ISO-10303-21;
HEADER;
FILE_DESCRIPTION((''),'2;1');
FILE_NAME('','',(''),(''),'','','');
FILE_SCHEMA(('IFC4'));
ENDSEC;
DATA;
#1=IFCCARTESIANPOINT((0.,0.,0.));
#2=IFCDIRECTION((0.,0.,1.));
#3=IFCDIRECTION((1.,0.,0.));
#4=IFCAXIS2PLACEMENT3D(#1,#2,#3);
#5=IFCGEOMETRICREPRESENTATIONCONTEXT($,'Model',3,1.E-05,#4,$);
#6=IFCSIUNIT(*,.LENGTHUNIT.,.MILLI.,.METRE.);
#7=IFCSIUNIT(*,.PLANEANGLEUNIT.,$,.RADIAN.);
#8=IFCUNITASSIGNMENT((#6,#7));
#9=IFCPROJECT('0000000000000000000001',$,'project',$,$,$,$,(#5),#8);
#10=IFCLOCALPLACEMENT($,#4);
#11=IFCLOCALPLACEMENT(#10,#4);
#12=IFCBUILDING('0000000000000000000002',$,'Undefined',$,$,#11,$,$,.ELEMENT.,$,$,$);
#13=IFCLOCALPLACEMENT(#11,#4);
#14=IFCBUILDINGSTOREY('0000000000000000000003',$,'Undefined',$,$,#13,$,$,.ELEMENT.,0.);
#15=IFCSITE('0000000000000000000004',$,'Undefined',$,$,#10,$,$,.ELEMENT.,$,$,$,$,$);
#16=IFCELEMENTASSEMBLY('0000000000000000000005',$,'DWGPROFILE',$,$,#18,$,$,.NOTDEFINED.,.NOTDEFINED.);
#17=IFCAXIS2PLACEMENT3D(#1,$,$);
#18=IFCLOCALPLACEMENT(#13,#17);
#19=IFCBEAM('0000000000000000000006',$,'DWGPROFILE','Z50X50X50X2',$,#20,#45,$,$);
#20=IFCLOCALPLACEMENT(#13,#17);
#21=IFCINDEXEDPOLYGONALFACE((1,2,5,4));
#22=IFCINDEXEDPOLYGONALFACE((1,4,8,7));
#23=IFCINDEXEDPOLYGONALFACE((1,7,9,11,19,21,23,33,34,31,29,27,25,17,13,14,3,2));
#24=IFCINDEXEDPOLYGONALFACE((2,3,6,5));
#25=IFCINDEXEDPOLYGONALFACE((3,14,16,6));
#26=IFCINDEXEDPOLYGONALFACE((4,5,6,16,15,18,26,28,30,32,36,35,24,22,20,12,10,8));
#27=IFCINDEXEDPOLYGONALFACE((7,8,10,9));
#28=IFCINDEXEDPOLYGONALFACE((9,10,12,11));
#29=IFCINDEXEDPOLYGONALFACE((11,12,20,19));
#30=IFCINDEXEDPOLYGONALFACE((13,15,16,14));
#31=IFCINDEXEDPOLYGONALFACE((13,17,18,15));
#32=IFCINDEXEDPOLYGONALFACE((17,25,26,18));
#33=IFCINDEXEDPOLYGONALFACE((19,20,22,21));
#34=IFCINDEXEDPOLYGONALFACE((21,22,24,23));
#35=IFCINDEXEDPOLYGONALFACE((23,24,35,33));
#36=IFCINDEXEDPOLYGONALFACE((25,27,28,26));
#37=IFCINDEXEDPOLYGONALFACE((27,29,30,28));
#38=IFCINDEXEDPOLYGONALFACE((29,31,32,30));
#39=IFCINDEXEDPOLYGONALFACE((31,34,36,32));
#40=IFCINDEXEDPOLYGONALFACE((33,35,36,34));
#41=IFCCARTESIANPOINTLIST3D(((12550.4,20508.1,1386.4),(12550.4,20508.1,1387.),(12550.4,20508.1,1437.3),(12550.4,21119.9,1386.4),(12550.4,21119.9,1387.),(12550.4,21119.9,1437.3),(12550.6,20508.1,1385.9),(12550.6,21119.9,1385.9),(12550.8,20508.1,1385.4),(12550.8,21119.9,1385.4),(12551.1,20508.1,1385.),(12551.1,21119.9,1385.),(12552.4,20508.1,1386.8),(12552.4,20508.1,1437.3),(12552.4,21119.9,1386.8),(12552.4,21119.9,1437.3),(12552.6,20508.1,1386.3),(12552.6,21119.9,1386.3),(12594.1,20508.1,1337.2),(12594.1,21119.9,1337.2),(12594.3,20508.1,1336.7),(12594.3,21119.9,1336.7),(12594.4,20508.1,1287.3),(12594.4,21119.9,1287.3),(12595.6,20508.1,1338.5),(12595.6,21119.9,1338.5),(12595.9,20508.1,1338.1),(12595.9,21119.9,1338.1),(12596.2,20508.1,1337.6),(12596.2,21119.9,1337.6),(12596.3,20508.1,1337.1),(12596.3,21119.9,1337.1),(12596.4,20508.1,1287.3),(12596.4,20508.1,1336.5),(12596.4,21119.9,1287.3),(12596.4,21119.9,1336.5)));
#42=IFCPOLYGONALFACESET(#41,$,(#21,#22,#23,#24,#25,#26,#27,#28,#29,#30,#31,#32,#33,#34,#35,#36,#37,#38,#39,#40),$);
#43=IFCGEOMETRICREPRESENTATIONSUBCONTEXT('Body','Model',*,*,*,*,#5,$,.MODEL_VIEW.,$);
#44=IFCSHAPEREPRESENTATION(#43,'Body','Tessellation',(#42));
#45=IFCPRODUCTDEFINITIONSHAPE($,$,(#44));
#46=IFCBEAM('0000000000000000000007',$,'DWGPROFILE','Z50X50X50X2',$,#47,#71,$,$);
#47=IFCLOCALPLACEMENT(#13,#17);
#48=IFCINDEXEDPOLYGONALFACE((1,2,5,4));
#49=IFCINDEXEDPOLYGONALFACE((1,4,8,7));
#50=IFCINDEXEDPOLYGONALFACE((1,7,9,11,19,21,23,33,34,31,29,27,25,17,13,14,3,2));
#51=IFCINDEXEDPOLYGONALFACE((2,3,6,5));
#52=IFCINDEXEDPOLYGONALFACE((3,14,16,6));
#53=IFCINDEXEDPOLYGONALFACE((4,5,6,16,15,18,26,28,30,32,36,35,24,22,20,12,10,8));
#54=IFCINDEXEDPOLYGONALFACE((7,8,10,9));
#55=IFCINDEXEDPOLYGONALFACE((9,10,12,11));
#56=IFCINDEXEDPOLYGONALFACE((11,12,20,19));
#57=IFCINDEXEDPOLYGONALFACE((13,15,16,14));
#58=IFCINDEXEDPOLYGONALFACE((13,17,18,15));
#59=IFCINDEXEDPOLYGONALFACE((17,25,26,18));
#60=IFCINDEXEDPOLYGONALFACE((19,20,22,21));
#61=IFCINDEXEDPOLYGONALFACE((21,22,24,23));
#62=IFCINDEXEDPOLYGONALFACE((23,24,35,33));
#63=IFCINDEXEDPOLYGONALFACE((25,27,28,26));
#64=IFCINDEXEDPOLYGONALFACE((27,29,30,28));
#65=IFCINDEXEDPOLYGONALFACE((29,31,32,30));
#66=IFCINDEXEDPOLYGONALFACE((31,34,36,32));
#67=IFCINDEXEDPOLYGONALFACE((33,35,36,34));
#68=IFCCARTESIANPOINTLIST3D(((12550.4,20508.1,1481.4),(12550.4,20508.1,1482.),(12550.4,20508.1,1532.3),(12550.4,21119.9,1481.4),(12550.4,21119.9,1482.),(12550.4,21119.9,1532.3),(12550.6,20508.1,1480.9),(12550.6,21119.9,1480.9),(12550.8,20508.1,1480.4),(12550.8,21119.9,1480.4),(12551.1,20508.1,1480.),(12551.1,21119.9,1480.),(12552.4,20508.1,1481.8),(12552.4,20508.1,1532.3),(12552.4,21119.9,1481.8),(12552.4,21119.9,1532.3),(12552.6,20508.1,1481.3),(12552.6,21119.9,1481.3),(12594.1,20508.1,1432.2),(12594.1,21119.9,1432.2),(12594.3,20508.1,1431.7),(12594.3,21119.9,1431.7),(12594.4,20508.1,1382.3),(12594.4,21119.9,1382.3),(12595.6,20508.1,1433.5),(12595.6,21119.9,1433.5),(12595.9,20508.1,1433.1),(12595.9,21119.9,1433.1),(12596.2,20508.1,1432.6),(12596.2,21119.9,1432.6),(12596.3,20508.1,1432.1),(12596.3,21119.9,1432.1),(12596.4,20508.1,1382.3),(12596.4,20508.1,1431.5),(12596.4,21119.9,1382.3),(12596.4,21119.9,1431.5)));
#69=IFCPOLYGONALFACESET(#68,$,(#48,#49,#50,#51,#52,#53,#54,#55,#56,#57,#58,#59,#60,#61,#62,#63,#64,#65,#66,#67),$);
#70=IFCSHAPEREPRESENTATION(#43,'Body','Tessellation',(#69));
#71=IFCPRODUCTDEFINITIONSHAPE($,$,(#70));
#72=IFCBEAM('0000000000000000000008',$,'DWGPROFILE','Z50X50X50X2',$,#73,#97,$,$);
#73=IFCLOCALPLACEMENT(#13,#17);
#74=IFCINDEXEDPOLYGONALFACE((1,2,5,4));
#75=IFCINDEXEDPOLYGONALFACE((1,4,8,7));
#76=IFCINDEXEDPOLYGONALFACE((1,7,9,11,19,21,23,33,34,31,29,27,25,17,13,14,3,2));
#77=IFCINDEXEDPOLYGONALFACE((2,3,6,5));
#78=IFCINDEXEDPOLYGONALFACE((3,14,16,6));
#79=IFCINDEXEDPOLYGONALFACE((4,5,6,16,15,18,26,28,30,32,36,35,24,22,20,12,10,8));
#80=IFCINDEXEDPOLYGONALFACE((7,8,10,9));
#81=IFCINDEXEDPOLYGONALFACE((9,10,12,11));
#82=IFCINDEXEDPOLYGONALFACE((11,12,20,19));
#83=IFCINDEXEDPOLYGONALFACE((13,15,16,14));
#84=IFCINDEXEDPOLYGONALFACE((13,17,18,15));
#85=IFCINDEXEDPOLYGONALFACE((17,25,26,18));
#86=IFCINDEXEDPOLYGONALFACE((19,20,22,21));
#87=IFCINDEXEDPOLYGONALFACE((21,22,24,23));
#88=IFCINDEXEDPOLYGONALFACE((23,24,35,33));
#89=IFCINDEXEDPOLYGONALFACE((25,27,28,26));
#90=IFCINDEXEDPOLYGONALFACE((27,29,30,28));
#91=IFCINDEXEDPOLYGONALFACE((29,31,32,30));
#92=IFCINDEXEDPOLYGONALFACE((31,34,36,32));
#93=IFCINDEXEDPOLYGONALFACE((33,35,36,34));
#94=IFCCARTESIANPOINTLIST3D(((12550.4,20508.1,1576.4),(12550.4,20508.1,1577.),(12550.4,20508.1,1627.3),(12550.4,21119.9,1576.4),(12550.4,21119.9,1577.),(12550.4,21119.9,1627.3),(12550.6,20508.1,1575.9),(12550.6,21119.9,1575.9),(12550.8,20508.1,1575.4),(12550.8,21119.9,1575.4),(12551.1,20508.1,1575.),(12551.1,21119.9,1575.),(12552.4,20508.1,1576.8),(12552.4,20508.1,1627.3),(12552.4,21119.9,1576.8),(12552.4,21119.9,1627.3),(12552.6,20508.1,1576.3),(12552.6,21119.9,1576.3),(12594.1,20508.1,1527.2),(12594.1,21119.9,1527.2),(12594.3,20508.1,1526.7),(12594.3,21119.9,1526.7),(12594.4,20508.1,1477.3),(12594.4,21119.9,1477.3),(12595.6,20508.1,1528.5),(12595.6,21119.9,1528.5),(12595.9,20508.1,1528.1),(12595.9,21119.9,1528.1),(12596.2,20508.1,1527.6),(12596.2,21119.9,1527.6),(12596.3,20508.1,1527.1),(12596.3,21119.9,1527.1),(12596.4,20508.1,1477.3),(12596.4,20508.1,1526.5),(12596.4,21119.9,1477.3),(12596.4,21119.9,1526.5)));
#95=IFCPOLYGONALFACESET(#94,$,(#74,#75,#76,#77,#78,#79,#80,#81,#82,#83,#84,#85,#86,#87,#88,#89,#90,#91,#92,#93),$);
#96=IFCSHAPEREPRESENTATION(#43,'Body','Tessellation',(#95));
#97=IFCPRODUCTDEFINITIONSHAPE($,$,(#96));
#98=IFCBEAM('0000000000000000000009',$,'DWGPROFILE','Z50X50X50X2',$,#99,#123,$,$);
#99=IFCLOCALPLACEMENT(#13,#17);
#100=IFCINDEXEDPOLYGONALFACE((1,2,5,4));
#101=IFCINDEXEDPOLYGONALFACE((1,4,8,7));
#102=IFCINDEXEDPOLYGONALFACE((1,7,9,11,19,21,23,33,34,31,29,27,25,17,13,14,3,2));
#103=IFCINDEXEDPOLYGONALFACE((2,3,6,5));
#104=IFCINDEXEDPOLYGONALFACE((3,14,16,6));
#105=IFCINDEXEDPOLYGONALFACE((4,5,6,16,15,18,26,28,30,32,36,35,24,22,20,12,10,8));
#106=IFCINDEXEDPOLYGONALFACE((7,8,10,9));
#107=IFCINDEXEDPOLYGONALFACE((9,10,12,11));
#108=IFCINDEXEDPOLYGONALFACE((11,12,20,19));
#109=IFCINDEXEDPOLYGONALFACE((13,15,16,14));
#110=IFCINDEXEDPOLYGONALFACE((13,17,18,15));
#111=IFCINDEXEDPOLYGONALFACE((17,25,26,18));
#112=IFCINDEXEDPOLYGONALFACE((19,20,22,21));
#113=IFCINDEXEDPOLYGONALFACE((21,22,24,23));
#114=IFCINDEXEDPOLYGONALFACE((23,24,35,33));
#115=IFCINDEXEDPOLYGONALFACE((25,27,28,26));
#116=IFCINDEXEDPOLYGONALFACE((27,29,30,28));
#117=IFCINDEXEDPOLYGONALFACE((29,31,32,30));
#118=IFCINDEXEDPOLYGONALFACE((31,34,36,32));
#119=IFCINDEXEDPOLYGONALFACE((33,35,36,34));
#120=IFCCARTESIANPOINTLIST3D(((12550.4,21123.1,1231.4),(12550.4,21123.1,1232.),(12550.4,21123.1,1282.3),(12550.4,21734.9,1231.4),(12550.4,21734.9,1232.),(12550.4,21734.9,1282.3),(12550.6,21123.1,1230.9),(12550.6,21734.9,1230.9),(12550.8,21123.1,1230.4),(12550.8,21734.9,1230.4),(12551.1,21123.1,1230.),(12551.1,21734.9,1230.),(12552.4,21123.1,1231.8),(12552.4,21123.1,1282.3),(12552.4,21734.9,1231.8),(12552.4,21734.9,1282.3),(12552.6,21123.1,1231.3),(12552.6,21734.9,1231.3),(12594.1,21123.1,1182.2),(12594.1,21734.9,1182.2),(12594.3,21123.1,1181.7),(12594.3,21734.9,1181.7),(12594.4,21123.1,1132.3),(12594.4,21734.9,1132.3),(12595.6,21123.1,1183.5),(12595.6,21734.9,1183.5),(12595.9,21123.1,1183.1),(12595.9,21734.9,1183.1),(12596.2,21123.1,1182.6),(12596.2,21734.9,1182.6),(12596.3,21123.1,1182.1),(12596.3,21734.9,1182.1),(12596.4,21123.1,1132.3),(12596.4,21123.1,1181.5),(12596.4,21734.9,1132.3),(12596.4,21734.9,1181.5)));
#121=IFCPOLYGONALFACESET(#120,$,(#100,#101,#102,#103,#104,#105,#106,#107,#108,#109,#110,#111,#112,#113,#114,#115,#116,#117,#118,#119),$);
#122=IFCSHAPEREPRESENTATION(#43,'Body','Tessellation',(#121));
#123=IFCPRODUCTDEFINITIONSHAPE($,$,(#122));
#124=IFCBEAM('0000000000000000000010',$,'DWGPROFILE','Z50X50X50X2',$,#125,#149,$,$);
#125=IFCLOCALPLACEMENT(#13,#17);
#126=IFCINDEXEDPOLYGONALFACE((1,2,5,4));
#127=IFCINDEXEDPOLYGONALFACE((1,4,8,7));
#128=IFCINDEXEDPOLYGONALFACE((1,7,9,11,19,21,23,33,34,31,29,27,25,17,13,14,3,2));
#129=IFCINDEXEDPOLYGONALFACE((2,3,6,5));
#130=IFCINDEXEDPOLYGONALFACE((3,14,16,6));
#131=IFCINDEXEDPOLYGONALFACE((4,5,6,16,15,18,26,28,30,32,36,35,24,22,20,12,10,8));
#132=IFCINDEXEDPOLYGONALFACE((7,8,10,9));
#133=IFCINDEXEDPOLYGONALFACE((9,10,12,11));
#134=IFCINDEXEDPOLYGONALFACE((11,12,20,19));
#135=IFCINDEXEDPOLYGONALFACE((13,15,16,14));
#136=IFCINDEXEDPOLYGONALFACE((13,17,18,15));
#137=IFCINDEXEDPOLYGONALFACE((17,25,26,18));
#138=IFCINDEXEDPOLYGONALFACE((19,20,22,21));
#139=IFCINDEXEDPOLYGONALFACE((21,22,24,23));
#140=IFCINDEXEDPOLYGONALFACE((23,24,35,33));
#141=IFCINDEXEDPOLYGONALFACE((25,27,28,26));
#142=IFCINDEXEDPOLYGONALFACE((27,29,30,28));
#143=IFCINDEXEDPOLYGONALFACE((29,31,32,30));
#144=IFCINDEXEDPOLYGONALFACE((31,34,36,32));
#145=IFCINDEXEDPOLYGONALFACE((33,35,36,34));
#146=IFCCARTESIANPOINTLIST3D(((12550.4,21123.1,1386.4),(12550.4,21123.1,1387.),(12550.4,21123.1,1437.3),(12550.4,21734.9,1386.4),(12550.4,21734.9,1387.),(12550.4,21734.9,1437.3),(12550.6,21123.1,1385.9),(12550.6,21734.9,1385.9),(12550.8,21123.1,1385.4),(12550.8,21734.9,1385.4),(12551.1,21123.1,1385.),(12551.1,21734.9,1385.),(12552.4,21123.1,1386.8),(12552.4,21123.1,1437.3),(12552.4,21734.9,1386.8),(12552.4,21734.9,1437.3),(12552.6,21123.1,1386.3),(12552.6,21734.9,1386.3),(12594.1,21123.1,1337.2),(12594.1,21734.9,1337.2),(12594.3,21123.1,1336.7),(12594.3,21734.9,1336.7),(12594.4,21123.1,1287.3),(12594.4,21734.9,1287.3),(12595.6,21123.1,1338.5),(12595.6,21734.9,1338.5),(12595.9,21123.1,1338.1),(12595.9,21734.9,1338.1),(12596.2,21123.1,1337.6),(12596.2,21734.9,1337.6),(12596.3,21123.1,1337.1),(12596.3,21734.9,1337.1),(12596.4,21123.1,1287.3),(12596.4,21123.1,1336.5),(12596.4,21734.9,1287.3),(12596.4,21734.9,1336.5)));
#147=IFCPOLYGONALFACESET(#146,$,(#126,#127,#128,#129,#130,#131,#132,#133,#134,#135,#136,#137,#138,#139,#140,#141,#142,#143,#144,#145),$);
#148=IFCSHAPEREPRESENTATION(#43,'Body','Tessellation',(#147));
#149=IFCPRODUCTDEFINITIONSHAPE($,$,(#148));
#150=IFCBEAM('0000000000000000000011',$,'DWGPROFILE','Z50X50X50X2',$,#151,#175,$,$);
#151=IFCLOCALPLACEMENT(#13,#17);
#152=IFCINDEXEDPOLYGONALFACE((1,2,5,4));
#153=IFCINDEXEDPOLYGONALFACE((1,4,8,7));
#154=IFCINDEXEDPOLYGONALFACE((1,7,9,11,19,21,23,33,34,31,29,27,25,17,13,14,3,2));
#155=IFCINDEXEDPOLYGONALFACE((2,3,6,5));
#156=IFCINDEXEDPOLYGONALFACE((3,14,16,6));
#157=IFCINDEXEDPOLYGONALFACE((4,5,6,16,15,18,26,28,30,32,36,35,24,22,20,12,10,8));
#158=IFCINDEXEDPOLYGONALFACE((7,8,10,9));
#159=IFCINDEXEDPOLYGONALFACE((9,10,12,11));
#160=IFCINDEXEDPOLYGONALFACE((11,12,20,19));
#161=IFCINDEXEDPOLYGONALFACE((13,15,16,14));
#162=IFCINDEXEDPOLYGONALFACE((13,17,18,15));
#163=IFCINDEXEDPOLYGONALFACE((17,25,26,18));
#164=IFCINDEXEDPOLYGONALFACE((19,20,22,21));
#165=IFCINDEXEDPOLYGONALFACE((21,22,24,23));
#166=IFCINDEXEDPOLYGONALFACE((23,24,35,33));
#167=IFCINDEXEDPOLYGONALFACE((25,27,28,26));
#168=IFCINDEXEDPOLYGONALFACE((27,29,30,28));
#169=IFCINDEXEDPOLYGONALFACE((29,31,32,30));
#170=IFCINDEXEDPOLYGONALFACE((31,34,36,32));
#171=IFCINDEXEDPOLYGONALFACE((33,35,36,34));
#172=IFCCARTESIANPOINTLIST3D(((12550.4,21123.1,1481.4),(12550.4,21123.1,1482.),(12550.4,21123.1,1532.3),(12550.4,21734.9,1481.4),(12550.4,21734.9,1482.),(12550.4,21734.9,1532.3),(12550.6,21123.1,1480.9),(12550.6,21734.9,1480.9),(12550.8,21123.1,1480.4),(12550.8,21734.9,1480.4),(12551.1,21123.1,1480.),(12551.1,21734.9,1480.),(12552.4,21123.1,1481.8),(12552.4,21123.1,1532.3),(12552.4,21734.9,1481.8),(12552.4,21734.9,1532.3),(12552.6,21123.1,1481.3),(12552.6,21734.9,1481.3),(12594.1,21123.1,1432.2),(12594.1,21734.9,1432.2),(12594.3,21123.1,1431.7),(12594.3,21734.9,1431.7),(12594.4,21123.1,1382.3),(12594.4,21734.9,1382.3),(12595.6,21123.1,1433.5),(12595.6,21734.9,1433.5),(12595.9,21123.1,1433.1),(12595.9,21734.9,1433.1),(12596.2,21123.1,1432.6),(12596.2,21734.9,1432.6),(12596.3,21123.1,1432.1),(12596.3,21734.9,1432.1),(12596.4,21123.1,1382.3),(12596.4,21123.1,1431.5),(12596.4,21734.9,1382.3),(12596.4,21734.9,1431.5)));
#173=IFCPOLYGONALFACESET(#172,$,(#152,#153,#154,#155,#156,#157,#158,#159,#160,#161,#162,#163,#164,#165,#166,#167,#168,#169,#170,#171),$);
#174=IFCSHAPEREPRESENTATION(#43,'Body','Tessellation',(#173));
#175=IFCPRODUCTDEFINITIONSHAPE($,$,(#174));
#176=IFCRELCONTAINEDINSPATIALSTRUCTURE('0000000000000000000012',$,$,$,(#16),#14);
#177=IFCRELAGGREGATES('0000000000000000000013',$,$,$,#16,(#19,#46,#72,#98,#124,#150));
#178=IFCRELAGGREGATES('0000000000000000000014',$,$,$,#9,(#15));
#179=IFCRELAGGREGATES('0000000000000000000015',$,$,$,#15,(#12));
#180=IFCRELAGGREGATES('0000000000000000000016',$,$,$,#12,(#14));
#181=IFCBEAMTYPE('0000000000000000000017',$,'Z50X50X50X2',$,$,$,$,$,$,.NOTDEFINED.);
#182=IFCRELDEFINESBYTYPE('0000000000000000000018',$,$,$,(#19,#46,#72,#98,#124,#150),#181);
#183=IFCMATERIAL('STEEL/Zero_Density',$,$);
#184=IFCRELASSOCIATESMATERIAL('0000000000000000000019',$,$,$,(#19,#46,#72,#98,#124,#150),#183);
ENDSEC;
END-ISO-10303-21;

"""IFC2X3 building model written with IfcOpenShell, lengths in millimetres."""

from ifc_helpers import new_model, si_unit, frame, origin_with_axes, place, context, subcontext, project, spatial, polyline, outline, extrude, material, type_object, element, aggregate, save


model = new_model("IFC2X3")

# Units and contexts
model_context = context("Model", 3, precision=1e-05, world=origin_with_axes())
body_context = subcontext(model_context, "Body", "Model", "MODEL_VIEW")
ifc_project = project(units=[si_unit("LENGTHUNIT", "METRE", prefix="MILLI"), si_unit("PLANEANGLEUNIT", "RADIAN")], contexts=[model_context])

# Site, building, storey
site_placement = place(None, origin_with_axes())
site = spatial("IfcSite", under=ifc_project, at=site_placement, Name="Undefined", CompositionType="ELEMENT")
building_placement = place(site_placement, origin_with_axes())
building = spatial("IfcBuilding", under=site, at=building_placement, Name="Undefined", CompositionType="ELEMENT")
storey_placement = place(building_placement, origin_with_axes())
storey = spatial("IfcBuildingStorey", under=building, at=storey_placement, Name="Undefined", CompositionType="ELEMENT", Elevation=0.0)

# Element assembly, beams
assembly_1_placement = place(storey_placement, origin_with_axes())
assembly_1 = element("IfcElementAssembly", 1, at=assembly_1_placement, inside=storey, Name="DWGPROFILE", AssemblyPlace="NOTDEFINED", PredefinedType="NOTDEFINED")
ifc_material_1 = material(Name="STEEL/Zero_Density")
beam_type_1 = type_object("IfcBeamType", Name="Z50X50X50X2", PredefinedType="NOTDEFINED")
beam_1_placement = place(assembly_1_placement, frame((12573.4, 20508.1, 1362.3), z_axis=(0.0, 0.0, 1.0), x_axis=(0.0, 1.0, 0.0)))
beam_1 = element("IfcBeam", 2, at=beam_1_placement, type_object=beam_type_1, material=ifc_material_1, Name="DWGPROFILE", Description="Z50X50X50X2", context=body_context, shape_type="SweptSolid", body=[
    extrude(outline(polyline([(-22.9, 24.1), (-23.0, 24.7), (-23.0, 75.0), (-21.0, 75.0), (-21.0, 24.5), (-20.7, 24.0), (22.2, -23.8), (22.6, -24.2), (22.8, -24.7), (22.9, -25.2), (23.0, -25.8), (23.0, -75.0), (21.0, -75.0), (21.0, -25.6), (20.7, -25.1), (-22.2, 22.6), (-22.6, 23.1), (-22.8, 23.6), (-22.9, 24.1)])), frame((611.8, 0.0, 0.0), z_axis=(-1.0, 0.0, 0.0), x_axis=(0.0, -1.0, 0.0)), (0.0, 0.0, 1.0), 611.8),
])
beam_2_placement = place(assembly_1_placement, frame((12573.4, 20508.1, 1457.3), z_axis=(0.0, 0.0, 1.0), x_axis=(0.0, 1.0, 0.0)))
beam_2 = element("IfcBeam", 3, at=beam_2_placement, type_object=beam_type_1, material=ifc_material_1, Name="DWGPROFILE", Description="Z50X50X50X2", context=body_context, shape_type="SweptSolid", body=[
    extrude(outline(polyline([(-22.9, 24.1), (-23.0, 24.7), (-23.0, 75.0), (-21.0, 75.0), (-21.0, 24.5), (-20.7, 24.0), (22.2, -23.8), (22.6, -24.2), (22.8, -24.7), (22.9, -25.2), (23.0, -25.8), (23.0, -75.0), (21.0, -75.0), (21.0, -25.6), (20.7, -25.1), (-22.2, 22.6), (-22.6, 23.1), (-22.8, 23.6), (-22.9, 24.1)])), frame((611.8, 0.0, 0.0), z_axis=(-1.0, 0.0, 0.0), x_axis=(0.0, -1.0, 0.0)), (0.0, 0.0, 1.0), 611.8),
])
beam_3_placement = place(assembly_1_placement, frame((12573.4, 20508.1, 1552.3), z_axis=(0.0, 0.0, 1.0), x_axis=(0.0, 1.0, 0.0)))
beam_3 = element("IfcBeam", 4, at=beam_3_placement, type_object=beam_type_1, material=ifc_material_1, Name="DWGPROFILE", Description="Z50X50X50X2", context=body_context, shape_type="SweptSolid", body=[
    extrude(outline(polyline([(-22.9, 24.1), (-23.0, 24.7), (-23.0, 75.0), (-21.0, 75.0), (-21.0, 24.5), (-20.7, 24.0), (22.2, -23.8), (22.6, -24.2), (22.8, -24.7), (22.9, -25.2), (23.0, -25.8), (23.0, -75.0), (21.0, -75.0), (21.0, -25.6), (20.7, -25.1), (-22.2, 22.6), (-22.6, 23.1), (-22.8, 23.6), (-22.9, 24.1)])), frame((611.8, 0.0, 0.0), z_axis=(-1.0, 0.0, 0.0), x_axis=(0.0, -1.0, 0.0)), (0.0, 0.0, 1.0), 611.8),
])
beam_4_placement = place(assembly_1_placement, frame((12573.4, 21123.1, 1207.3), z_axis=(0.0, 0.0, 1.0), x_axis=(0.0, 1.0, 0.0)))
beam_4 = element("IfcBeam", 5, at=beam_4_placement, type_object=beam_type_1, material=ifc_material_1, Name="DWGPROFILE", Description="Z50X50X50X2", context=body_context, shape_type="SweptSolid", body=[
    extrude(outline(polyline([(-22.9, 24.1), (-23.0, 24.7), (-23.0, 75.0), (-21.0, 75.0), (-21.0, 24.5), (-20.7, 24.0), (22.2, -23.8), (22.6, -24.2), (22.8, -24.7), (22.9, -25.2), (23.0, -25.8), (23.0, -75.0), (21.0, -75.0), (21.0, -25.6), (20.7, -25.1), (-22.2, 22.6), (-22.6, 23.1), (-22.8, 23.6), (-22.9, 24.1)])), frame((611.8, 0.0, 0.0), z_axis=(-1.0, 0.0, 0.0), x_axis=(0.0, -1.0, 0.0)), (0.0, 0.0, 1.0), 611.8),
])
beam_5_placement = place(assembly_1_placement, frame((12573.4, 21123.1, 1362.3), z_axis=(0.0, 0.0, 1.0), x_axis=(0.0, 1.0, 0.0)))
beam_5 = element("IfcBeam", 6, at=beam_5_placement, type_object=beam_type_1, material=ifc_material_1, Name="DWGPROFILE", Description="Z50X50X50X2", context=body_context, shape_type="SweptSolid", body=[
    extrude(outline(polyline([(-22.9, 24.1), (-23.0, 24.7), (-23.0, 75.0), (-21.0, 75.0), (-21.0, 24.5), (-20.7, 24.0), (22.2, -23.8), (22.6, -24.2), (22.8, -24.7), (22.9, -25.2), (23.0, -25.8), (23.0, -75.0), (21.0, -75.0), (21.0, -25.6), (20.7, -25.1), (-22.2, 22.6), (-22.6, 23.1), (-22.8, 23.6), (-22.9, 24.1)])), frame((611.8, 0.0, 0.0), z_axis=(-1.0, 0.0, 0.0), x_axis=(0.0, -1.0, 0.0)), (0.0, 0.0, 1.0), 611.8),
])
beam_6_placement = place(assembly_1_placement, frame((12573.4, 21123.1, 1457.3), z_axis=(0.0, 0.0, 1.0), x_axis=(0.0, 1.0, 0.0)))
beam_6 = element("IfcBeam", 7, at=beam_6_placement, type_object=beam_type_1, material=ifc_material_1, Name="DWGPROFILE", Description="Z50X50X50X2", context=body_context, shape_type="SweptSolid", body=[
    extrude(outline(polyline([(-22.9, 24.1), (-23.0, 24.7), (-23.0, 75.0), (-21.0, 75.0), (-21.0, 24.5), (-20.7, 24.0), (22.2, -23.8), (22.6, -24.2), (22.8, -24.7), (22.9, -25.2), (23.0, -25.8), (23.0, -75.0), (21.0, -75.0), (21.0, -25.6), (20.7, -25.1), (-22.2, 22.6), (-22.6, 23.1), (-22.8, 23.6), (-22.9, 24.1)])), frame((611.8, 0.0, 0.0), z_axis=(-1.0, 0.0, 0.0), x_axis=(0.0, -1.0, 0.0)), (0.0, 0.0, 1.0), 611.8),
])

aggregate(assembly_1, [beam_1, beam_2, beam_3, beam_4, beam_5, beam_6])

save(model, "model.ifc")
